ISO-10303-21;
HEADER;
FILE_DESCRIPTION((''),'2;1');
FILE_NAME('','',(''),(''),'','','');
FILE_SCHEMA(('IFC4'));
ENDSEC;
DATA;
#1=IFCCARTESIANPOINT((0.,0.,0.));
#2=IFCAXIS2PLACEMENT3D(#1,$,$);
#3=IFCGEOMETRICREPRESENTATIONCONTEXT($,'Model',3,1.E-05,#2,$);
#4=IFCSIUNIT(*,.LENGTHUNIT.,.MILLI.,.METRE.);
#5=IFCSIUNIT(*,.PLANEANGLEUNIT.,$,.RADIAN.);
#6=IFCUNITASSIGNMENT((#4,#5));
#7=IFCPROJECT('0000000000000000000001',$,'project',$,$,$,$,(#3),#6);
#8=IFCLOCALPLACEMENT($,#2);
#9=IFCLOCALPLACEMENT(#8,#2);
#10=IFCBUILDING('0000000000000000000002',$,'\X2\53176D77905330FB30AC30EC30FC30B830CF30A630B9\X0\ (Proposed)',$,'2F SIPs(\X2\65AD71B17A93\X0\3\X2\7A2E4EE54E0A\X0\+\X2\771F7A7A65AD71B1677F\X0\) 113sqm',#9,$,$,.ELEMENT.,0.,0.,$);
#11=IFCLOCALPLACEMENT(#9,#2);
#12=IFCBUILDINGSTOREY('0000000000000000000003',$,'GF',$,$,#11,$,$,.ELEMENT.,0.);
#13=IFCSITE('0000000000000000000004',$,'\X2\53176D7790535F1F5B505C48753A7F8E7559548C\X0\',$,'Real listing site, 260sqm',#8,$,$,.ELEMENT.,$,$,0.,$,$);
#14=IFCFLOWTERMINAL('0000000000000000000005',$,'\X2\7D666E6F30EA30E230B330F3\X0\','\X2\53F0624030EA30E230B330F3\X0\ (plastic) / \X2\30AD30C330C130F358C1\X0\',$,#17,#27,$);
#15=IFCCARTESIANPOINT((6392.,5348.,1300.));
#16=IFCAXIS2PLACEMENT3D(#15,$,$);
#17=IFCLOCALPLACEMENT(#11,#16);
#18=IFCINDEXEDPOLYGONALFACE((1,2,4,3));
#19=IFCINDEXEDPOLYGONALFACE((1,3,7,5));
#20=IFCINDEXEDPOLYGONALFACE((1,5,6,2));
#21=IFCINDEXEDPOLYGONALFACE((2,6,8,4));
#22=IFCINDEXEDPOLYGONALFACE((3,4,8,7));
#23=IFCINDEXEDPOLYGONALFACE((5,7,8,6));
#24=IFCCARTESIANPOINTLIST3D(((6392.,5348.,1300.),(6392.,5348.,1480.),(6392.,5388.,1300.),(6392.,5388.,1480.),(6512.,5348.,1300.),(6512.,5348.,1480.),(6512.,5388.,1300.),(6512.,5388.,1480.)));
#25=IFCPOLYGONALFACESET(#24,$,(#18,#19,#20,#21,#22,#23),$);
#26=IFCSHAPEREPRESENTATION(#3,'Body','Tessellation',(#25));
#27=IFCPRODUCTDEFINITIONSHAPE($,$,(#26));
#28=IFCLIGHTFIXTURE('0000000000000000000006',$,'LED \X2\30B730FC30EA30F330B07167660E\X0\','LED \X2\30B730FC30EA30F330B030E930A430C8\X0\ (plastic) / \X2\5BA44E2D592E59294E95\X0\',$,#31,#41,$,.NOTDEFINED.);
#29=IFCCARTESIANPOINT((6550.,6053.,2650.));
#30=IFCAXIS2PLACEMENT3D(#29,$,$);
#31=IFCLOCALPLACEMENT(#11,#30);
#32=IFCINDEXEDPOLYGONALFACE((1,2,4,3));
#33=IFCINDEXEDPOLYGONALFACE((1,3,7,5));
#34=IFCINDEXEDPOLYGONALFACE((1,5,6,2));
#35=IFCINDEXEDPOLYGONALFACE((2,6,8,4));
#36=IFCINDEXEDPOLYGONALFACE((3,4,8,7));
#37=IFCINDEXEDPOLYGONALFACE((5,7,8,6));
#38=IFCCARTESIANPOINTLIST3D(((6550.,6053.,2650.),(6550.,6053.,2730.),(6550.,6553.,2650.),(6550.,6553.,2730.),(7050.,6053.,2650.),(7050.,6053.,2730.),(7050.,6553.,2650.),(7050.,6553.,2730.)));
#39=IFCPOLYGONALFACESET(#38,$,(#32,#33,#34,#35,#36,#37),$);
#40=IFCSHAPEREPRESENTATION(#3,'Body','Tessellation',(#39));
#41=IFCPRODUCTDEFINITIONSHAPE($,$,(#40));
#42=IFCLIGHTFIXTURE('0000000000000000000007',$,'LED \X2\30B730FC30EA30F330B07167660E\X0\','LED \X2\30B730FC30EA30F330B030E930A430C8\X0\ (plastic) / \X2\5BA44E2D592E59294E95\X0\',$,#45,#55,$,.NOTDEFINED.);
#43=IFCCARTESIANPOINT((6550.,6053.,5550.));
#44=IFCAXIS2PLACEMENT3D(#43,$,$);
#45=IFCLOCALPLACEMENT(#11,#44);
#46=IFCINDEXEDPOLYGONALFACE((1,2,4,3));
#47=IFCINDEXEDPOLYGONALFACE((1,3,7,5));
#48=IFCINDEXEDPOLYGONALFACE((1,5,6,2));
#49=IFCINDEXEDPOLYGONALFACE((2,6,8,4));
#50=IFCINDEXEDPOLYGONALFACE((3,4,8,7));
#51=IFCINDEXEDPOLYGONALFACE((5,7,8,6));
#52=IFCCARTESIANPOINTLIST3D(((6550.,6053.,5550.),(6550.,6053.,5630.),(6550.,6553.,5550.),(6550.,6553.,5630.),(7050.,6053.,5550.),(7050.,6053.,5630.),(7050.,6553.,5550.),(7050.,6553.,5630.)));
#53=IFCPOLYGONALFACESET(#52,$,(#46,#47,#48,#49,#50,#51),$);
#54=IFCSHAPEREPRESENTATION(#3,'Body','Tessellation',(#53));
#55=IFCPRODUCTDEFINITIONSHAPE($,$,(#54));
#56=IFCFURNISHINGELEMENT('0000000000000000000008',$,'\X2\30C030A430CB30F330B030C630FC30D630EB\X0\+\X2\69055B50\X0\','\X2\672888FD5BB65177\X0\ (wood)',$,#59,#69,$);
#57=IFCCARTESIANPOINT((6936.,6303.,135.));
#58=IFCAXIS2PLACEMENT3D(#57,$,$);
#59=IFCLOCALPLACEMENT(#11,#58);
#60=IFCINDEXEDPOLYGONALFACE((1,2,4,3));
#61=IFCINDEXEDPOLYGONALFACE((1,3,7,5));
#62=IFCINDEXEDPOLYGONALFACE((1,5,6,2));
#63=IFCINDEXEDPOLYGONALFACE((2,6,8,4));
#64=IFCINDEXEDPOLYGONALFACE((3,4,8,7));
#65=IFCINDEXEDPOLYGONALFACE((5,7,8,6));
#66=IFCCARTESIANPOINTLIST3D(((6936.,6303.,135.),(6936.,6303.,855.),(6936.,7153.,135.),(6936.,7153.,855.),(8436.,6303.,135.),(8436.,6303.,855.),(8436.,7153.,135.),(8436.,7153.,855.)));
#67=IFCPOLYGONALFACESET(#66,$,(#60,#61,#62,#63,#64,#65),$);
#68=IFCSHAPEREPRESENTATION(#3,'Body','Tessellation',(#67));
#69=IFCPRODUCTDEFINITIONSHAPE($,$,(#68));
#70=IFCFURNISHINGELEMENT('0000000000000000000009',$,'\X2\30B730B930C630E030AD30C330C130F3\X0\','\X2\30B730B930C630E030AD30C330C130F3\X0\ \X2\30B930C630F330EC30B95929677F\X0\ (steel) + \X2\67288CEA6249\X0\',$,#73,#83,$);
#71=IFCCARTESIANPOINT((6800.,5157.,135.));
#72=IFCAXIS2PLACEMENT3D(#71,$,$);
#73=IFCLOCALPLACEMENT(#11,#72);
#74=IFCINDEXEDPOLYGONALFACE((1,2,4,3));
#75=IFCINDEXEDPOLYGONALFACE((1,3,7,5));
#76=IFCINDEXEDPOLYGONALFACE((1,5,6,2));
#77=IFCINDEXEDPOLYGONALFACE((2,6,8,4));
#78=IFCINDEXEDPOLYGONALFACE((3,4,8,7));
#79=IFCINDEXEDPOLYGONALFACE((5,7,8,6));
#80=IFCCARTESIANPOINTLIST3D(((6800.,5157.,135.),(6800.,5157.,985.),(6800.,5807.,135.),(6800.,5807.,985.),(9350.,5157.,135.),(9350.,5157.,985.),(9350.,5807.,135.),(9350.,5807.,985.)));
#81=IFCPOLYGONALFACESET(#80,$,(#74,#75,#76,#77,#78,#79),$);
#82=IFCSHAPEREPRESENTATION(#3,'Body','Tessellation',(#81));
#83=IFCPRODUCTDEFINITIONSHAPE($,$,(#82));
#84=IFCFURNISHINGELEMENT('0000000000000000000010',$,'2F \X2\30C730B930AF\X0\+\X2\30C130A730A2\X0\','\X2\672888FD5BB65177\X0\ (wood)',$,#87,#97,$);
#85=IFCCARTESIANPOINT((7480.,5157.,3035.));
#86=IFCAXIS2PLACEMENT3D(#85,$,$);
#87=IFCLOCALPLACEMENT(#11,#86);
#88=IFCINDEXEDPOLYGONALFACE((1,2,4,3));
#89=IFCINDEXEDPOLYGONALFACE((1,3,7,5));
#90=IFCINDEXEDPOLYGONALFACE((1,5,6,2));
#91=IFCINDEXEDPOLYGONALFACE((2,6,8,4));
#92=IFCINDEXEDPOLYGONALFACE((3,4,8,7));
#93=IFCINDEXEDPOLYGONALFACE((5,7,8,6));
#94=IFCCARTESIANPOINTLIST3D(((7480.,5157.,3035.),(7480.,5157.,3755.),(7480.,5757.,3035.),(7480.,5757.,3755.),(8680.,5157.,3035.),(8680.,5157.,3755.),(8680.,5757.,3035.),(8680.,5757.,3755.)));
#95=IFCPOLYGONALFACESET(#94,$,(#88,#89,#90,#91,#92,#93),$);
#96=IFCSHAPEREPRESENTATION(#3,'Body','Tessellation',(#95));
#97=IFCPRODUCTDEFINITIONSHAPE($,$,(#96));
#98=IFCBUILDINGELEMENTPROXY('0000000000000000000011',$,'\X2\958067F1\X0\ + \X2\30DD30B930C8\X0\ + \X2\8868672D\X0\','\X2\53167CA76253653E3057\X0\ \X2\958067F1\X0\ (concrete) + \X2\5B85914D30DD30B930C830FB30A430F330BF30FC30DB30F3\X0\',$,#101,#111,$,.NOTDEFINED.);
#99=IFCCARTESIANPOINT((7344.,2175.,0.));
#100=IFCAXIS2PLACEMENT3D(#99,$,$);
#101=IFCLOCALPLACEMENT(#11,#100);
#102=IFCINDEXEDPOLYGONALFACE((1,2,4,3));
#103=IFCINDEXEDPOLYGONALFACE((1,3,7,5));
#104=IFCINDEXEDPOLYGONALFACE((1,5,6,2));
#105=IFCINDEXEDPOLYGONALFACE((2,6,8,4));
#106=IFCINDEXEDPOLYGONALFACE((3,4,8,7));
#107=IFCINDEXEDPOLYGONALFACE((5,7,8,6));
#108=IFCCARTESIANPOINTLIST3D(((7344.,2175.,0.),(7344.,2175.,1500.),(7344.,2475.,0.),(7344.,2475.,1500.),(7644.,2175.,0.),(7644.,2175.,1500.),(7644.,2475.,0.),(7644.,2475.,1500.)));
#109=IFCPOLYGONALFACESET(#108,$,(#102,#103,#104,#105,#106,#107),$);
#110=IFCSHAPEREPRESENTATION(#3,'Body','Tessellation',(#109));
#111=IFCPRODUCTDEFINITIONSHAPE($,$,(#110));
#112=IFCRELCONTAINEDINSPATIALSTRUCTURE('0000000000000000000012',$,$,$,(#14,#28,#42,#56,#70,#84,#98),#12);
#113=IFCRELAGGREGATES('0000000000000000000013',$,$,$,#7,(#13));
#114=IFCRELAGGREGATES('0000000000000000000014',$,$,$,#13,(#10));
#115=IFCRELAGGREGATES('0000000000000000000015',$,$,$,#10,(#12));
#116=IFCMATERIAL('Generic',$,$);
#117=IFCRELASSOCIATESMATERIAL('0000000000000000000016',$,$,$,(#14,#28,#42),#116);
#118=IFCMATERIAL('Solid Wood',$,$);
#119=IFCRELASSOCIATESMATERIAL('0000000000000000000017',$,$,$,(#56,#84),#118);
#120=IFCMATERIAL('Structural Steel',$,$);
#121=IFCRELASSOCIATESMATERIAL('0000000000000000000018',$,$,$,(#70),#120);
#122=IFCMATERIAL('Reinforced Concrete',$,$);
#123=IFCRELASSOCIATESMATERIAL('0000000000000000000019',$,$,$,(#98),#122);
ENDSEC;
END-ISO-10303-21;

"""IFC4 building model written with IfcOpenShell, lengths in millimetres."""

from ifc_helpers import new_model, si_unit, frame, frame_2d, origin, place, context, project, spatial, rectangle, extrude, material, element, save


model = new_model("IFC4")

# Units and contexts
model_context = context("Model", 3, precision=1e-05, world=origin())
ifc_project = project(units=[si_unit("LENGTHUNIT", "METRE", prefix="MILLI"), si_unit("PLANEANGLEUNIT", "RADIAN")], contexts=[model_context])

# Site, building, storey
site_placement = place(None, origin())
site = spatial("IfcSite", under=ifc_project, at=site_placement, Name="北海道弟子屈町美留和", ObjectType="Real listing site, 260sqm", CompositionType="ELEMENT", RefElevation=0.0)
building_placement = place(site_placement, origin())
building = spatial("IfcBuilding", under=site, at=building_placement, Name="北海道・ガレージハウス (Proposed)", ObjectType="2F SIPs(断熱窓3種以上+真空断熱板) 113sqm", CompositionType="ELEMENT", ElevationOfRefHeight=0.0, ElevationOfTerrain=0.0)
storey_placement = place(building_placement, origin())
storey = spatial("IfcBuildingStorey", under=building, at=storey_placement, Name="GF", CompositionType="ELEMENT", Elevation=0.0)

# Shared definitions
ifc_material_1 = material(Name="Solid Wood")

# Shared definitions
ifc_material_2 = material(Name="Structural Steel")

# Shared definitions
ifc_material_3 = material(Name="Reinforced Concrete")

# Flow terminal
ifc_material_4 = material(Name="Generic")
flow_terminal_1_placement = place(storey_placement, frame((6392.0, 5348.0, 1300.0)))
element("IfcFlowTerminal", 1, at=flow_terminal_1_placement, inside=storey, material=ifc_material_4, Name="給湯リモコン", Description="台所リモコン (plastic) / キッチン壁", context=model_context, shape_type="SweptSolid", body=[
    extrude(rectangle(XDim=120.0, YDim=40.0, at=frame_2d((60.0, 20.0))), frame((6392.0, 5348.0, 1300.0)), (0.0, 0.0, 1.0), 180.0),
])

# Light fixtures
light_fixture_1_placement = place(storey_placement, frame((6550.0, 6053.0, 2650.0)))
element("IfcLightFixture", 2, at=light_fixture_1_placement, inside=storey, material=ifc_material_4, Name="LED シーリング照明", Description="LED シーリングライト (plastic) / 室中央天井", PredefinedType="NOTDEFINED", context=model_context, shape_type="SweptSolid", body=[
    extrude(rectangle(XDim=500.0, YDim=500.0, at=frame_2d((250.0, 250.0))), frame((6550.0, 6053.0, 2650.0)), (0.0, 0.0, 1.0), 80.0),
])
light_fixture_2_placement = place(storey_placement, frame((6550.0, 6053.0, 5550.0)))
element("IfcLightFixture", 3, at=light_fixture_2_placement, inside=storey, material=ifc_material_4, Name="LED シーリング照明", Description="LED シーリングライト (plastic) / 室中央天井", PredefinedType="NOTDEFINED", context=model_context, shape_type="SweptSolid", body=[
    extrude(rectangle(XDim=500.0, YDim=500.0, at=frame_2d((250.0, 250.0))), frame((6550.0, 6053.0, 5550.0)), (0.0, 0.0, 1.0), 80.0),
])

# Furnishing elements
furnishing_1_placement = place(storey_placement, frame((6936.0, 6303.0, 135.0)))
element("IfcFurnishingElement", 4, at=furnishing_1_placement, inside=storey, material=ifc_material_1, Name="ダイニングテーブル+椅子", Description="木製家具 (wood)", context=model_context, shape_type="SweptSolid", body=[
    extrude(rectangle(XDim=1500.0, YDim=850.0, at=frame_2d((750.0, 425.0))), frame((6936.0, 6303.0, 135.0)), (0.0, 0.0, 1.0), 720.0),
])
furnishing_2_placement = place(storey_placement, frame((6800.0, 5157.0, 135.0)))
element("IfcFurnishingElement", 5, at=furnishing_2_placement, inside=storey, material=ifc_material_2, Name="システムキッチン", Description="システムキッチン ステンレス天板 (steel) + 木質扉", context=model_context, shape_type="SweptSolid", body=[
    extrude(rectangle(XDim=2550.0, YDim=650.0, at=frame_2d((1275.0, 325.0))), frame((6800.0, 5157.0, 135.0)), (0.0, 0.0, 1.0), 850.0),
])
furnishing_3_placement = place(storey_placement, frame((7480.0, 5157.0, 3035.0)))
element("IfcFurnishingElement", 6, at=furnishing_3_placement, inside=storey, material=ifc_material_1, Name="2F デスク+チェア", Description="木製家具 (wood)", context=model_context, shape_type="SweptSolid", body=[
    extrude(rectangle(XDim=1200.0, YDim=600.0, at=frame_2d((600.0, 300.0))), frame((7480.0, 5157.0, 3035.0)), (0.0, 0.0, 1.0), 720.0),
])

# Building element proxy
proxy_placement = place(storey_placement, frame((7344.0, 2175.0, 0.0)))
element("IfcBuildingElementProxy", 7, at=proxy_placement, inside=storey, material=ifc_material_3, Name="門柱 + ポスト + 表札", Description="化粧打放し 門柱 (concrete) + 宅配ポスト・インターホン", PredefinedType="NOTDEFINED", context=model_context, shape_type="SweptSolid", body=[
    extrude(rectangle(XDim=300.0, YDim=300.0, at=frame_2d((150.0, 150.0))), frame((7344.0, 2175.0, 0.0)), (0.0, 0.0, 1.0), 1500.0),
])

save(model, "model.ifc")
